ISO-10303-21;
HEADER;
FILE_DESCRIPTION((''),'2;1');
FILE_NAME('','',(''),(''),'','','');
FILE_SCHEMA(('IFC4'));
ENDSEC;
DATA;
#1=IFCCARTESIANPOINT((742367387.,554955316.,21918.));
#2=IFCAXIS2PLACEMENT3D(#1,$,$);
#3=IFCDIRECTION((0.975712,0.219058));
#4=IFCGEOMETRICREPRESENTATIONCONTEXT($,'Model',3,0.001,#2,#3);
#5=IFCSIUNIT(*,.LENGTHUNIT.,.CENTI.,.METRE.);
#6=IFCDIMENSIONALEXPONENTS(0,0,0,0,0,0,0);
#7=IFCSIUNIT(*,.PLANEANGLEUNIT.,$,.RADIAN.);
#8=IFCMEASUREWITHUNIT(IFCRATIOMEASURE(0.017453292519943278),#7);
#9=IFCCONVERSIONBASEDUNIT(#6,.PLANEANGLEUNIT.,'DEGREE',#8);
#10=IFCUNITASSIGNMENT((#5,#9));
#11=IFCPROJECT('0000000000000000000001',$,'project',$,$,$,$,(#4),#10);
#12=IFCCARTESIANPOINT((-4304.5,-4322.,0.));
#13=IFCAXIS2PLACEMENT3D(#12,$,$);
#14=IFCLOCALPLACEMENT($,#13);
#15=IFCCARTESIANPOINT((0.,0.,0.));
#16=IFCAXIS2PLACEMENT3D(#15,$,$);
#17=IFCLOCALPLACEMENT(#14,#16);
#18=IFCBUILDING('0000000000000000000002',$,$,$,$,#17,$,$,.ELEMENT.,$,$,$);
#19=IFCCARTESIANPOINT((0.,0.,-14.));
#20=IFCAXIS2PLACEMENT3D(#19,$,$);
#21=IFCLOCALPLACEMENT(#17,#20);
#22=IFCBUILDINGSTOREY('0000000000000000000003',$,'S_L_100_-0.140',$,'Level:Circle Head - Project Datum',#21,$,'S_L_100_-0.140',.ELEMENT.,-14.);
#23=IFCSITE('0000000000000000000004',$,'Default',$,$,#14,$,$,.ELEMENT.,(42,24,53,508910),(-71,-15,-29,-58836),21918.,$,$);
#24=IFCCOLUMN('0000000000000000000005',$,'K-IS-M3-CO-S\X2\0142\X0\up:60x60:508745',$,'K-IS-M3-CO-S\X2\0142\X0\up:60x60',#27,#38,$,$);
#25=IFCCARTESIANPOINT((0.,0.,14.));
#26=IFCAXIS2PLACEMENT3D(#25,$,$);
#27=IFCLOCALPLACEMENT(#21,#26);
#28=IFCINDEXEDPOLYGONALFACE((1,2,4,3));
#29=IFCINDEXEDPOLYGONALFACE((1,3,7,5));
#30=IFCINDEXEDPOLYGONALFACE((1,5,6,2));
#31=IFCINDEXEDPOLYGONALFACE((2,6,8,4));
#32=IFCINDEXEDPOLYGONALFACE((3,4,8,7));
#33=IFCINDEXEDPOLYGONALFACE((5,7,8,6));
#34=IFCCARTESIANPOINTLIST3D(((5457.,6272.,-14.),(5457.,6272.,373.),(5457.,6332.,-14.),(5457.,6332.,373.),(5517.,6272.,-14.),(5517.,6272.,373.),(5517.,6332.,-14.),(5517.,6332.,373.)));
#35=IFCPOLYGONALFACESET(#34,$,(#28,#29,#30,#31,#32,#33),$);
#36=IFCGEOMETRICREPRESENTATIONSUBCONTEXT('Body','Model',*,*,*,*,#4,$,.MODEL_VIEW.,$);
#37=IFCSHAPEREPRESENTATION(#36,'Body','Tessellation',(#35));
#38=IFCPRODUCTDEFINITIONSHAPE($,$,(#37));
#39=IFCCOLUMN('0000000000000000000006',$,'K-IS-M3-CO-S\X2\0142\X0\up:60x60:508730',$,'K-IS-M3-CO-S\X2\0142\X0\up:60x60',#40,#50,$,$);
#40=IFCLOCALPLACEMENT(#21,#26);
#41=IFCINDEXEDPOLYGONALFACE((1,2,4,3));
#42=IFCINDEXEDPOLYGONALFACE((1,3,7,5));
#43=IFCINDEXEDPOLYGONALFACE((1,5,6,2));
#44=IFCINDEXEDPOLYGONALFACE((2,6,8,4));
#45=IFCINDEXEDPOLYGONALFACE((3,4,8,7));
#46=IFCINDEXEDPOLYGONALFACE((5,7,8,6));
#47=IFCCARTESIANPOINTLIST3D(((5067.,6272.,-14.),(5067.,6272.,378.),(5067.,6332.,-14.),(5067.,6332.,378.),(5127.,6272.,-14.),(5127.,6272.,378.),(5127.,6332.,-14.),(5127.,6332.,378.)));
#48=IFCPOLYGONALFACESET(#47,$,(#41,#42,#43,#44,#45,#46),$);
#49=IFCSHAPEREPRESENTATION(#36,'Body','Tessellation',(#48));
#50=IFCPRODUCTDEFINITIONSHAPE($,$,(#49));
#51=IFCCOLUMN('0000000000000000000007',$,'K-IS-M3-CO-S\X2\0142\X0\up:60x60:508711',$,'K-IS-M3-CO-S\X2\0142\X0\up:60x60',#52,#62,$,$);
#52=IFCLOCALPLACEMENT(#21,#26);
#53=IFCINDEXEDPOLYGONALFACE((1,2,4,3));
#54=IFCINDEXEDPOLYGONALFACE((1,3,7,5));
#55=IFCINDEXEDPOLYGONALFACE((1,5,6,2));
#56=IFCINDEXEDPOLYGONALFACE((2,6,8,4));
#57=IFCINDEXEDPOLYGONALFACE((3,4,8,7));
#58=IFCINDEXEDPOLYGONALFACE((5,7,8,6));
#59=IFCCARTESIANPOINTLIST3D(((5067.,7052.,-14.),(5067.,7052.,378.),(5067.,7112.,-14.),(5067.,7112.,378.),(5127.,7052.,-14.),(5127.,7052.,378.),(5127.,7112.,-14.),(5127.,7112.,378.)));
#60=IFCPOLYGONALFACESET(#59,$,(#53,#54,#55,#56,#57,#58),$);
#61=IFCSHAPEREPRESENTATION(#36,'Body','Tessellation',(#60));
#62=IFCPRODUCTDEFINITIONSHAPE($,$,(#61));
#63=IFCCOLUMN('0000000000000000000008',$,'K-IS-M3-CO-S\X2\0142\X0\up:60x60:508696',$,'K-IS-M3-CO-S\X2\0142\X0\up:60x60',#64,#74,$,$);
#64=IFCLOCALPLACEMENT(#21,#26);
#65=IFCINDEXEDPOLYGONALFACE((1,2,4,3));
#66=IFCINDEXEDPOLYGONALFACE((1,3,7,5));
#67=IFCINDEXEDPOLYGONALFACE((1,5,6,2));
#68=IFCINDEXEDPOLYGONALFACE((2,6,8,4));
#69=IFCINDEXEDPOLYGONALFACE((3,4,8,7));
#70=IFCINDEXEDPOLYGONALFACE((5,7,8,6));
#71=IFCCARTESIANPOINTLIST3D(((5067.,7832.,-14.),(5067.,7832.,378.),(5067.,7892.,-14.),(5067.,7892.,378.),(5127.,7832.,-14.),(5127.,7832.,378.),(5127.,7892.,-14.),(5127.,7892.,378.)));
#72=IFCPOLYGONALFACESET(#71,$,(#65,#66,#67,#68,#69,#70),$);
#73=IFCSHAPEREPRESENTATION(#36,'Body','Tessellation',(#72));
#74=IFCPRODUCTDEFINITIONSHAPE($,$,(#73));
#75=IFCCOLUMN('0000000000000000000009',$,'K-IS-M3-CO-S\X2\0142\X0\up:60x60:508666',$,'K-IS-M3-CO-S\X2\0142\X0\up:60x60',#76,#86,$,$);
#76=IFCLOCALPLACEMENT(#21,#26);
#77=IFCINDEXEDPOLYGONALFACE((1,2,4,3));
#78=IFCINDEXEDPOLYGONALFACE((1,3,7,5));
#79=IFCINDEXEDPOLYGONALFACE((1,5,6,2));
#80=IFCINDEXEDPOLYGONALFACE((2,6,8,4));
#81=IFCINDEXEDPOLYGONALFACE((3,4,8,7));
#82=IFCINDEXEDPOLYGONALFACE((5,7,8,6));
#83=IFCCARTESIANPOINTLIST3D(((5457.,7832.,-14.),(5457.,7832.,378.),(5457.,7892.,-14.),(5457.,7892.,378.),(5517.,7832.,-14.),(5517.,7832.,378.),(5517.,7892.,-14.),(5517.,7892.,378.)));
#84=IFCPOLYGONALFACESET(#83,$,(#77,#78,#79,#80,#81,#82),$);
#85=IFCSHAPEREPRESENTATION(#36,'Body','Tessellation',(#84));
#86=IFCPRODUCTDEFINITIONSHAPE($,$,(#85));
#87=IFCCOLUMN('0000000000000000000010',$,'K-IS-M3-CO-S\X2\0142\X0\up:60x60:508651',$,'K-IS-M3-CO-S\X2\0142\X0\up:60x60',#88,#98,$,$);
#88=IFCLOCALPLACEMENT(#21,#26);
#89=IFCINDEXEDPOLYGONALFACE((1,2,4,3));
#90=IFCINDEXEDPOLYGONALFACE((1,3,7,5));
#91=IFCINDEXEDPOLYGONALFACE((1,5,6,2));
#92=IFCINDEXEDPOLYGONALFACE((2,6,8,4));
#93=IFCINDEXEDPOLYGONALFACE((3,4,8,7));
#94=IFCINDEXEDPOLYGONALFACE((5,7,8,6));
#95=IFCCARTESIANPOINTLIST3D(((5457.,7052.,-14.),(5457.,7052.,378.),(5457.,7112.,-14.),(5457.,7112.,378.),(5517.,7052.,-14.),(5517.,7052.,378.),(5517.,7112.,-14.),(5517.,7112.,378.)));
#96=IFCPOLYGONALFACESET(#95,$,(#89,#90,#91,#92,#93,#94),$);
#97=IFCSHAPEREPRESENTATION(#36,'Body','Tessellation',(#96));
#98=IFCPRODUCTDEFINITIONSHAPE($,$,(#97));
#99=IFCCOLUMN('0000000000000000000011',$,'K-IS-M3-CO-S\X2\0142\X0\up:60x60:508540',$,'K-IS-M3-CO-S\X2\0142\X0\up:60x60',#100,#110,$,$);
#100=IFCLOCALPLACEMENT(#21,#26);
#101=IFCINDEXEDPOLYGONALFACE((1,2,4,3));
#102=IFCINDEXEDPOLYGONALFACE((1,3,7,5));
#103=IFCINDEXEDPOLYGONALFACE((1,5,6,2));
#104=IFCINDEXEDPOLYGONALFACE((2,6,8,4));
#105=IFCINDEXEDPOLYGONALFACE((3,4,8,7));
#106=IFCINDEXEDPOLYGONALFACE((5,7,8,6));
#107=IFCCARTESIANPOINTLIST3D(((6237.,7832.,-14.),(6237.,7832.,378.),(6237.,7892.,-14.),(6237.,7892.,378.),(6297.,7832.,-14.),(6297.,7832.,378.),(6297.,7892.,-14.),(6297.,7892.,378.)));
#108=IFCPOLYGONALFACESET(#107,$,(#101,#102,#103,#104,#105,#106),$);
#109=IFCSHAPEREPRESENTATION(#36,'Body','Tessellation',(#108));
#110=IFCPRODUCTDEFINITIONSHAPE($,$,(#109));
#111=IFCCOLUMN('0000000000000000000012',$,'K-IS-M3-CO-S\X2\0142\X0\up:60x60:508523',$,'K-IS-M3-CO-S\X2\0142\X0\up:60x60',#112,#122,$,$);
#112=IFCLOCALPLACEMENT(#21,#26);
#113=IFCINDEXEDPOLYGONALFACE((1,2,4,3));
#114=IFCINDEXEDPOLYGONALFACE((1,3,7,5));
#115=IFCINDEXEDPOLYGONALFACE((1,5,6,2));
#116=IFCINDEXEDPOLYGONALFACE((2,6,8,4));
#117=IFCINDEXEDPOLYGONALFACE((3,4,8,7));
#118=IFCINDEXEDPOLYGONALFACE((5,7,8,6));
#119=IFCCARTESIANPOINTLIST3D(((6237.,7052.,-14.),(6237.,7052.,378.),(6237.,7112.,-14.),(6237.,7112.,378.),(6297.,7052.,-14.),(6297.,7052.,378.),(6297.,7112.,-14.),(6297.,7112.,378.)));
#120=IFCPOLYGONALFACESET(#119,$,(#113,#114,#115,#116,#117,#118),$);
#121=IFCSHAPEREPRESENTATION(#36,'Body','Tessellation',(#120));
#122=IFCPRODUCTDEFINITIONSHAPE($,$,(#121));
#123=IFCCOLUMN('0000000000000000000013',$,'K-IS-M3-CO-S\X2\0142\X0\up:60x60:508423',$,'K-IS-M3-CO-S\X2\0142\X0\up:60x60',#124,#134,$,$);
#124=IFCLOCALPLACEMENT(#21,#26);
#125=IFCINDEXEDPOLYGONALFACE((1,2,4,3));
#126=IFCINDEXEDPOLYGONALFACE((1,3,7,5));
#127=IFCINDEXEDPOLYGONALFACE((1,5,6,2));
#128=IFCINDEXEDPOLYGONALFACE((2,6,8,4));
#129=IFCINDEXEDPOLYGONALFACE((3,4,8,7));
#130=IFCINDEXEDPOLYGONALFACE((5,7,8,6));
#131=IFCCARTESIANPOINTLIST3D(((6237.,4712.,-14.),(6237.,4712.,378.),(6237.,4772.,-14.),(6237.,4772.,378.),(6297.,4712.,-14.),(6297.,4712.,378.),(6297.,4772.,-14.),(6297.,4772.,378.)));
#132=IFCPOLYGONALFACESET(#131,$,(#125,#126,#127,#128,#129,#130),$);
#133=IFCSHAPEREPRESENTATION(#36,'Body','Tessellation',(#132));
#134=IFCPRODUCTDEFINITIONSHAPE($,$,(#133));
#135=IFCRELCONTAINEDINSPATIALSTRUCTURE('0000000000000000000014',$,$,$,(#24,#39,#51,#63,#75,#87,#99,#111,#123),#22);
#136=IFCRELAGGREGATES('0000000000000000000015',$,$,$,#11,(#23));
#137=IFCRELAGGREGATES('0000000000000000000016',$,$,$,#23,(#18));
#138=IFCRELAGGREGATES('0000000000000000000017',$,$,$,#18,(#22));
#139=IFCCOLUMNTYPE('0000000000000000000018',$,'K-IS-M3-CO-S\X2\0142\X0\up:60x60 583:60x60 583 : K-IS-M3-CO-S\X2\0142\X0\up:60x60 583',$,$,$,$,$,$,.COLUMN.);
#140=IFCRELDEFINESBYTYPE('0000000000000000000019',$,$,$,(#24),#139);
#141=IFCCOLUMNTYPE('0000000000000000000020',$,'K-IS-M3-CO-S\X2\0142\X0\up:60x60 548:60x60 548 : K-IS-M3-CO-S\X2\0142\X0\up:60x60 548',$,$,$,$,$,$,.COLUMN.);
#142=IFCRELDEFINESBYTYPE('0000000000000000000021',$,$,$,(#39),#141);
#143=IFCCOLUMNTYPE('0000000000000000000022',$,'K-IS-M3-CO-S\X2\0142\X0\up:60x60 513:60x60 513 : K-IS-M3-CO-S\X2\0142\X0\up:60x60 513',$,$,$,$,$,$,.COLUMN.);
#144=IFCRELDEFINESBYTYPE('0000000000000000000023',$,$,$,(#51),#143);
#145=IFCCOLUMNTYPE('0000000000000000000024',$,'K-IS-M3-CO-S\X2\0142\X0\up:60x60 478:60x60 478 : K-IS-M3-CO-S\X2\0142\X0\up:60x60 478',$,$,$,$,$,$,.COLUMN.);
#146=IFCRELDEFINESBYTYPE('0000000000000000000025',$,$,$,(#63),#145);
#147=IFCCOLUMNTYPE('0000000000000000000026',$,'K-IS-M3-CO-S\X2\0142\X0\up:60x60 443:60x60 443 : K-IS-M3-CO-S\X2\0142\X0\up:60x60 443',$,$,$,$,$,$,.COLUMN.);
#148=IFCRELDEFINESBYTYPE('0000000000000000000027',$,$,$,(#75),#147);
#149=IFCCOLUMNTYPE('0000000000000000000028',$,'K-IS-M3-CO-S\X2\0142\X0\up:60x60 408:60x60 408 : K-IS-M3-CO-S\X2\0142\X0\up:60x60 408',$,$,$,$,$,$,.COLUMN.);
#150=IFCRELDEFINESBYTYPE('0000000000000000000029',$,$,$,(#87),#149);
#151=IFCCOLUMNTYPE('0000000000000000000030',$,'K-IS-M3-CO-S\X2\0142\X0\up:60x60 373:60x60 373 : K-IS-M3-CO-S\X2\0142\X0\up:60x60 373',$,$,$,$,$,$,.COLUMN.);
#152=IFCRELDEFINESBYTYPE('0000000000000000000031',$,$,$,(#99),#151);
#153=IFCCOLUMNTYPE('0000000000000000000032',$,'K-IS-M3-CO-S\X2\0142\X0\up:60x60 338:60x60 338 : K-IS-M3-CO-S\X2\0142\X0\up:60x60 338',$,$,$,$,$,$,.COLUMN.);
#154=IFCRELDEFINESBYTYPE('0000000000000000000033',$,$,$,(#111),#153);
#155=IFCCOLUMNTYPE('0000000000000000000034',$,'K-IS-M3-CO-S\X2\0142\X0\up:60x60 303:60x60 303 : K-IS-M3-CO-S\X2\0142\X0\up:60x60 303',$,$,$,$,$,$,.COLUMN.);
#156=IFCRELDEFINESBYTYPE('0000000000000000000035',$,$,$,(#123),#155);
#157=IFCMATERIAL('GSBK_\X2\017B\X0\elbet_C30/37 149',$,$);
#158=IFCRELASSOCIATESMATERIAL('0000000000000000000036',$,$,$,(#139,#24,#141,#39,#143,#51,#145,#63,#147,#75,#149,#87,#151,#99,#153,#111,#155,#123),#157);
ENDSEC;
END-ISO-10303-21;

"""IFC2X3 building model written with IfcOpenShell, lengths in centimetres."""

from ifc_helpers import new_model, entity, si_unit, converted_unit, direction, frame, frame_2d, origin, origin_2d_with_axis, place, context, subcontext, project, spatial, rectangle, extrude, source, transform, mapped, material, type_object, type_shapes, element, save


model = new_model("IFC2X3")

# Units and contexts
model_context = context("Model", 3, precision=0.001, world=frame((742367387.0, 554955316.0, 21918.0)), true_north=direction((0.975712, 0.219058)))
body_context = subcontext(model_context, "Body", "Model", "MODEL_VIEW")
ifc_project = project(units=[si_unit("LENGTHUNIT", "METRE", prefix="CENTI"), converted_unit("PLANEANGLEUNIT", "DEGREE", entity("IfcRatioMeasure", 0.017453292519943278), si_unit("PLANEANGLEUNIT", "RADIAN"), dimensions=[0, 0, 0, 0, 0, 0, 0])], contexts=[model_context])

# Site, building, storey
site_placement = place(None, frame((-4304.5, -4322.0, 0.0)))
site = spatial("IfcSite", under=ifc_project, at=site_placement, Name="Default", CompositionType="ELEMENT", RefLatitude=(42, 24, 53, 508910), RefLongitude=(-71, -15, -29, -58836), RefElevation=21918.0)
building_placement = place(site_placement, origin())
building = spatial("IfcBuilding", under=site, at=building_placement, CompositionType="ELEMENT")
storey_placement = place(building_placement, frame((0.0, 0.0, -14.0)))
storey = spatial("IfcBuildingStorey", under=building, at=storey_placement, Name="S_L_100_-0.140", ObjectType="Level:Circle Head - Project Datum", LongName="S_L_100_-0.140", CompositionType="ELEMENT", Elevation=-14.0)

# Columns
ifc_material = material(Name="GSBK_Żelbet_C30/37 149")
column_type_1 = type_object("IfcColumnType", Name="K-IS-M3-CO-Słup:60x60 583:60x60 583 : K-IS-M3-CO-Słup:60x60 583", PredefinedType="COLUMN", material=ifc_material)
shared_shape_1 = source(origin(), body_context, "Body", "SweptSolid", [
    extrude(rectangle(XDim=60.0, YDim=60.0, at=origin_2d_with_axis()), frame((5487.0, 6302.0, -14.0), z_axis=(0.0, 0.0, 1.0), x_axis=(0.0, -1.0, 0.0)), (0.0, 0.0, 1.0), 387.0),
])
type_shapes(column_type_1, [shared_shape_1])
column_1_placement = place(storey_placement, frame((0.0, 0.0, 14.0)))
element("IfcColumn", 1, at=column_1_placement, inside=storey, type_object=column_type_1, material=ifc_material, Name="K-IS-M3-CO-Słup:60x60:508745", ObjectType="K-IS-M3-CO-Słup:60x60", context=body_context, shape_type="MappedRepresentation", body=[
    mapped(shared_shape_1, transform((0.0, 0.0, 0.0), scale=1.0)),
])
column_type_2 = type_object("IfcColumnType", Name="K-IS-M3-CO-Słup:60x60 548:60x60 548 : K-IS-M3-CO-Słup:60x60 548", PredefinedType="COLUMN", material=ifc_material)
shared_shape_2 = source(origin(), body_context, "Body", "SweptSolid", [
    extrude(rectangle(XDim=60.0, YDim=60.0, at=origin_2d_with_axis()), frame((5097.0, 6302.0, -14.0), z_axis=(0.0, 0.0, 1.0), x_axis=(0.0, -1.0, 0.0)), (0.0, 0.0, 1.0), 392.0),
])
type_shapes(column_type_2, [shared_shape_2])
column_2_placement = place(storey_placement, frame((0.0, 0.0, 14.0)))
element("IfcColumn", 2, at=column_2_placement, inside=storey, type_object=column_type_2, material=ifc_material, Name="K-IS-M3-CO-Słup:60x60:508730", ObjectType="K-IS-M3-CO-Słup:60x60", context=body_context, shape_type="MappedRepresentation", body=[
    mapped(shared_shape_2, transform((0.0, 0.0, 0.0), scale=1.0)),
])
column_type_3 = type_object("IfcColumnType", Name="K-IS-M3-CO-Słup:60x60 513:60x60 513 : K-IS-M3-CO-Słup:60x60 513", PredefinedType="COLUMN", material=ifc_material)
shared_shape_3 = source(origin(), body_context, "Body", "SweptSolid", [
    extrude(rectangle(XDim=60.0, YDim=60.0, at=origin_2d_with_axis()), frame((5097.0, 7082.0, -14.0), z_axis=(0.0, 0.0, 1.0), x_axis=(0.0, -1.0, 0.0)), (0.0, 0.0, 1.0), 392.0),
])
type_shapes(column_type_3, [shared_shape_3])
column_3_placement = place(storey_placement, frame((0.0, 0.0, 14.0)))
element("IfcColumn", 3, at=column_3_placement, inside=storey, type_object=column_type_3, material=ifc_material, Name="K-IS-M3-CO-Słup:60x60:508711", ObjectType="K-IS-M3-CO-Słup:60x60", context=body_context, shape_type="MappedRepresentation", body=[
    mapped(shared_shape_3, transform((0.0, 0.0, 0.0), scale=1.0)),
])
column_type_4 = type_object("IfcColumnType", Name="K-IS-M3-CO-Słup:60x60 478:60x60 478 : K-IS-M3-CO-Słup:60x60 478", PredefinedType="COLUMN", material=ifc_material)
shared_shape_4 = source(origin(), body_context, "Body", "SweptSolid", [
    extrude(rectangle(XDim=60.0, YDim=60.0, at=origin_2d_with_axis()), frame((5097.0, 7862.0, -14.0), z_axis=(0.0, 0.0, 1.0), x_axis=(0.0, -1.0, 0.0)), (0.0, 0.0, 1.0), 392.0),
])
type_shapes(column_type_4, [shared_shape_4])
column_4_placement = place(storey_placement, frame((0.0, 0.0, 14.0)))
element("IfcColumn", 4, at=column_4_placement, inside=storey, type_object=column_type_4, material=ifc_material, Name="K-IS-M3-CO-Słup:60x60:508696", ObjectType="K-IS-M3-CO-Słup:60x60", context=body_context, shape_type="MappedRepresentation", body=[
    mapped(shared_shape_4, transform((0.0, 0.0, 0.0), scale=1.0)),
])
column_type_5 = type_object("IfcColumnType", Name="K-IS-M3-CO-Słup:60x60 443:60x60 443 : K-IS-M3-CO-Słup:60x60 443", PredefinedType="COLUMN", material=ifc_material)
shared_shape_5 = source(origin(), body_context, "Body", "SweptSolid", [
    extrude(rectangle(XDim=60.0, YDim=60.0, at=origin_2d_with_axis()), frame((5487.0, 7862.0, -14.0), z_axis=(0.0, 0.0, 1.0), x_axis=(0.0, -1.0, 0.0)), (0.0, 0.0, 1.0), 392.0),
])
type_shapes(column_type_5, [shared_shape_5])
column_5_placement = place(storey_placement, frame((0.0, 0.0, 14.0)))
element("IfcColumn", 5, at=column_5_placement, inside=storey, type_object=column_type_5, material=ifc_material, Name="K-IS-M3-CO-Słup:60x60:508666", ObjectType="K-IS-M3-CO-Słup:60x60", context=body_context, shape_type="MappedRepresentation", body=[
    mapped(shared_shape_5, transform((0.0, 0.0, 0.0), scale=1.0)),
])
column_type_6 = type_object("IfcColumnType", Name="K-IS-M3-CO-Słup:60x60 408:60x60 408 : K-IS-M3-CO-Słup:60x60 408", PredefinedType="COLUMN", material=ifc_material)
shared_shape_6 = source(origin(), body_context, "Body", "SweptSolid", [
    extrude(rectangle(XDim=60.0, YDim=60.0, at=origin_2d_with_axis()), frame((5487.0, 7082.0, -14.0), z_axis=(0.0, 0.0, 1.0), x_axis=(0.0, -1.0, 0.0)), (0.0, 0.0, 1.0), 392.0),
])
type_shapes(column_type_6, [shared_shape_6])
column_6_placement = place(storey_placement, frame((0.0, 0.0, 14.0)))
element("IfcColumn", 6, at=column_6_placement, inside=storey, type_object=column_type_6, material=ifc_material, Name="K-IS-M3-CO-Słup:60x60:508651", ObjectType="K-IS-M3-CO-Słup:60x60", context=body_context, shape_type="MappedRepresentation", body=[
    mapped(shared_shape_6, transform((0.0, 0.0, 0.0), scale=1.0)),
])
column_type_7 = type_object("IfcColumnType", Name="K-IS-M3-CO-Słup:60x60 373:60x60 373 : K-IS-M3-CO-Słup:60x60 373", PredefinedType="COLUMN", material=ifc_material)
shared_shape_7 = source(origin(), body_context, "Body", "SweptSolid", [
    extrude(rectangle(XDim=60.0, YDim=60.0, at=origin_2d_with_axis()), frame((6267.0, 7862.0, -14.0), z_axis=(0.0, 0.0, 1.0), x_axis=(0.0, -1.0, 0.0)), (0.0, 0.0, 1.0), 392.0),
])
type_shapes(column_type_7, [shared_shape_7])
column_7_placement = place(storey_placement, frame((0.0, 0.0, 14.0)))
element("IfcColumn", 7, at=column_7_placement, inside=storey, type_object=column_type_7, material=ifc_material, Name="K-IS-M3-CO-Słup:60x60:508540", ObjectType="K-IS-M3-CO-Słup:60x60", context=body_context, shape_type="MappedRepresentation", body=[
    mapped(shared_shape_7, transform((0.0, 0.0, 0.0), scale=1.0)),
])
column_type_8 = type_object("IfcColumnType", Name="K-IS-M3-CO-Słup:60x60 338:60x60 338 : K-IS-M3-CO-Słup:60x60 338", PredefinedType="COLUMN", material=ifc_material)
shared_shape_8 = source(origin(), body_context, "Body", "SweptSolid", [
    extrude(rectangle(XDim=60.0, YDim=60.0, at=origin_2d_with_axis()), frame((6267.0, 7082.0, -14.0), z_axis=(0.0, 0.0, 1.0), x_axis=(0.0, -1.0, 0.0)), (0.0, 0.0, 1.0), 392.0),
])
type_shapes(column_type_8, [shared_shape_8])
column_8_placement = place(storey_placement, frame((0.0, 0.0, 14.0)))
element("IfcColumn", 8, at=column_8_placement, inside=storey, type_object=column_type_8, material=ifc_material, Name="K-IS-M3-CO-Słup:60x60:508523", ObjectType="K-IS-M3-CO-Słup:60x60", context=body_context, shape_type="MappedRepresentation", body=[
    mapped(shared_shape_8, transform((0.0, 0.0, 0.0), scale=1.0)),
])
column_type_9 = type_object("IfcColumnType", Name="K-IS-M3-CO-Słup:60x60 303:60x60 303 : K-IS-M3-CO-Słup:60x60 303", PredefinedType="COLUMN", material=ifc_material)
shared_shape_9 = source(origin(), body_context, "Body", "SweptSolid", [
    extrude(rectangle(XDim=60.0, YDim=60.0, at=frame_2d((0.0, 0.0), x_axis=(1.0, 0.0))), frame((6267.0, 4742.0, -14.0), z_axis=(0.0, 0.0, 1.0), x_axis=(0.0, -1.0, 0.0)), (0.0, 0.0, 1.0), 392.0),
])
type_shapes(column_type_9, [shared_shape_9])
column_9_placement = place(storey_placement, frame((0.0, 0.0, 14.0)))
element("IfcColumn", 9, at=column_9_placement, inside=storey, type_object=column_type_9, material=ifc_material, Name="K-IS-M3-CO-Słup:60x60:508423", ObjectType="K-IS-M3-CO-Słup:60x60", context=body_context, shape_type="MappedRepresentation", body=[
    mapped(shared_shape_9, transform((0.0, 0.0, 0.0), scale=1.0)),
])

save(model, "model.ifc")
